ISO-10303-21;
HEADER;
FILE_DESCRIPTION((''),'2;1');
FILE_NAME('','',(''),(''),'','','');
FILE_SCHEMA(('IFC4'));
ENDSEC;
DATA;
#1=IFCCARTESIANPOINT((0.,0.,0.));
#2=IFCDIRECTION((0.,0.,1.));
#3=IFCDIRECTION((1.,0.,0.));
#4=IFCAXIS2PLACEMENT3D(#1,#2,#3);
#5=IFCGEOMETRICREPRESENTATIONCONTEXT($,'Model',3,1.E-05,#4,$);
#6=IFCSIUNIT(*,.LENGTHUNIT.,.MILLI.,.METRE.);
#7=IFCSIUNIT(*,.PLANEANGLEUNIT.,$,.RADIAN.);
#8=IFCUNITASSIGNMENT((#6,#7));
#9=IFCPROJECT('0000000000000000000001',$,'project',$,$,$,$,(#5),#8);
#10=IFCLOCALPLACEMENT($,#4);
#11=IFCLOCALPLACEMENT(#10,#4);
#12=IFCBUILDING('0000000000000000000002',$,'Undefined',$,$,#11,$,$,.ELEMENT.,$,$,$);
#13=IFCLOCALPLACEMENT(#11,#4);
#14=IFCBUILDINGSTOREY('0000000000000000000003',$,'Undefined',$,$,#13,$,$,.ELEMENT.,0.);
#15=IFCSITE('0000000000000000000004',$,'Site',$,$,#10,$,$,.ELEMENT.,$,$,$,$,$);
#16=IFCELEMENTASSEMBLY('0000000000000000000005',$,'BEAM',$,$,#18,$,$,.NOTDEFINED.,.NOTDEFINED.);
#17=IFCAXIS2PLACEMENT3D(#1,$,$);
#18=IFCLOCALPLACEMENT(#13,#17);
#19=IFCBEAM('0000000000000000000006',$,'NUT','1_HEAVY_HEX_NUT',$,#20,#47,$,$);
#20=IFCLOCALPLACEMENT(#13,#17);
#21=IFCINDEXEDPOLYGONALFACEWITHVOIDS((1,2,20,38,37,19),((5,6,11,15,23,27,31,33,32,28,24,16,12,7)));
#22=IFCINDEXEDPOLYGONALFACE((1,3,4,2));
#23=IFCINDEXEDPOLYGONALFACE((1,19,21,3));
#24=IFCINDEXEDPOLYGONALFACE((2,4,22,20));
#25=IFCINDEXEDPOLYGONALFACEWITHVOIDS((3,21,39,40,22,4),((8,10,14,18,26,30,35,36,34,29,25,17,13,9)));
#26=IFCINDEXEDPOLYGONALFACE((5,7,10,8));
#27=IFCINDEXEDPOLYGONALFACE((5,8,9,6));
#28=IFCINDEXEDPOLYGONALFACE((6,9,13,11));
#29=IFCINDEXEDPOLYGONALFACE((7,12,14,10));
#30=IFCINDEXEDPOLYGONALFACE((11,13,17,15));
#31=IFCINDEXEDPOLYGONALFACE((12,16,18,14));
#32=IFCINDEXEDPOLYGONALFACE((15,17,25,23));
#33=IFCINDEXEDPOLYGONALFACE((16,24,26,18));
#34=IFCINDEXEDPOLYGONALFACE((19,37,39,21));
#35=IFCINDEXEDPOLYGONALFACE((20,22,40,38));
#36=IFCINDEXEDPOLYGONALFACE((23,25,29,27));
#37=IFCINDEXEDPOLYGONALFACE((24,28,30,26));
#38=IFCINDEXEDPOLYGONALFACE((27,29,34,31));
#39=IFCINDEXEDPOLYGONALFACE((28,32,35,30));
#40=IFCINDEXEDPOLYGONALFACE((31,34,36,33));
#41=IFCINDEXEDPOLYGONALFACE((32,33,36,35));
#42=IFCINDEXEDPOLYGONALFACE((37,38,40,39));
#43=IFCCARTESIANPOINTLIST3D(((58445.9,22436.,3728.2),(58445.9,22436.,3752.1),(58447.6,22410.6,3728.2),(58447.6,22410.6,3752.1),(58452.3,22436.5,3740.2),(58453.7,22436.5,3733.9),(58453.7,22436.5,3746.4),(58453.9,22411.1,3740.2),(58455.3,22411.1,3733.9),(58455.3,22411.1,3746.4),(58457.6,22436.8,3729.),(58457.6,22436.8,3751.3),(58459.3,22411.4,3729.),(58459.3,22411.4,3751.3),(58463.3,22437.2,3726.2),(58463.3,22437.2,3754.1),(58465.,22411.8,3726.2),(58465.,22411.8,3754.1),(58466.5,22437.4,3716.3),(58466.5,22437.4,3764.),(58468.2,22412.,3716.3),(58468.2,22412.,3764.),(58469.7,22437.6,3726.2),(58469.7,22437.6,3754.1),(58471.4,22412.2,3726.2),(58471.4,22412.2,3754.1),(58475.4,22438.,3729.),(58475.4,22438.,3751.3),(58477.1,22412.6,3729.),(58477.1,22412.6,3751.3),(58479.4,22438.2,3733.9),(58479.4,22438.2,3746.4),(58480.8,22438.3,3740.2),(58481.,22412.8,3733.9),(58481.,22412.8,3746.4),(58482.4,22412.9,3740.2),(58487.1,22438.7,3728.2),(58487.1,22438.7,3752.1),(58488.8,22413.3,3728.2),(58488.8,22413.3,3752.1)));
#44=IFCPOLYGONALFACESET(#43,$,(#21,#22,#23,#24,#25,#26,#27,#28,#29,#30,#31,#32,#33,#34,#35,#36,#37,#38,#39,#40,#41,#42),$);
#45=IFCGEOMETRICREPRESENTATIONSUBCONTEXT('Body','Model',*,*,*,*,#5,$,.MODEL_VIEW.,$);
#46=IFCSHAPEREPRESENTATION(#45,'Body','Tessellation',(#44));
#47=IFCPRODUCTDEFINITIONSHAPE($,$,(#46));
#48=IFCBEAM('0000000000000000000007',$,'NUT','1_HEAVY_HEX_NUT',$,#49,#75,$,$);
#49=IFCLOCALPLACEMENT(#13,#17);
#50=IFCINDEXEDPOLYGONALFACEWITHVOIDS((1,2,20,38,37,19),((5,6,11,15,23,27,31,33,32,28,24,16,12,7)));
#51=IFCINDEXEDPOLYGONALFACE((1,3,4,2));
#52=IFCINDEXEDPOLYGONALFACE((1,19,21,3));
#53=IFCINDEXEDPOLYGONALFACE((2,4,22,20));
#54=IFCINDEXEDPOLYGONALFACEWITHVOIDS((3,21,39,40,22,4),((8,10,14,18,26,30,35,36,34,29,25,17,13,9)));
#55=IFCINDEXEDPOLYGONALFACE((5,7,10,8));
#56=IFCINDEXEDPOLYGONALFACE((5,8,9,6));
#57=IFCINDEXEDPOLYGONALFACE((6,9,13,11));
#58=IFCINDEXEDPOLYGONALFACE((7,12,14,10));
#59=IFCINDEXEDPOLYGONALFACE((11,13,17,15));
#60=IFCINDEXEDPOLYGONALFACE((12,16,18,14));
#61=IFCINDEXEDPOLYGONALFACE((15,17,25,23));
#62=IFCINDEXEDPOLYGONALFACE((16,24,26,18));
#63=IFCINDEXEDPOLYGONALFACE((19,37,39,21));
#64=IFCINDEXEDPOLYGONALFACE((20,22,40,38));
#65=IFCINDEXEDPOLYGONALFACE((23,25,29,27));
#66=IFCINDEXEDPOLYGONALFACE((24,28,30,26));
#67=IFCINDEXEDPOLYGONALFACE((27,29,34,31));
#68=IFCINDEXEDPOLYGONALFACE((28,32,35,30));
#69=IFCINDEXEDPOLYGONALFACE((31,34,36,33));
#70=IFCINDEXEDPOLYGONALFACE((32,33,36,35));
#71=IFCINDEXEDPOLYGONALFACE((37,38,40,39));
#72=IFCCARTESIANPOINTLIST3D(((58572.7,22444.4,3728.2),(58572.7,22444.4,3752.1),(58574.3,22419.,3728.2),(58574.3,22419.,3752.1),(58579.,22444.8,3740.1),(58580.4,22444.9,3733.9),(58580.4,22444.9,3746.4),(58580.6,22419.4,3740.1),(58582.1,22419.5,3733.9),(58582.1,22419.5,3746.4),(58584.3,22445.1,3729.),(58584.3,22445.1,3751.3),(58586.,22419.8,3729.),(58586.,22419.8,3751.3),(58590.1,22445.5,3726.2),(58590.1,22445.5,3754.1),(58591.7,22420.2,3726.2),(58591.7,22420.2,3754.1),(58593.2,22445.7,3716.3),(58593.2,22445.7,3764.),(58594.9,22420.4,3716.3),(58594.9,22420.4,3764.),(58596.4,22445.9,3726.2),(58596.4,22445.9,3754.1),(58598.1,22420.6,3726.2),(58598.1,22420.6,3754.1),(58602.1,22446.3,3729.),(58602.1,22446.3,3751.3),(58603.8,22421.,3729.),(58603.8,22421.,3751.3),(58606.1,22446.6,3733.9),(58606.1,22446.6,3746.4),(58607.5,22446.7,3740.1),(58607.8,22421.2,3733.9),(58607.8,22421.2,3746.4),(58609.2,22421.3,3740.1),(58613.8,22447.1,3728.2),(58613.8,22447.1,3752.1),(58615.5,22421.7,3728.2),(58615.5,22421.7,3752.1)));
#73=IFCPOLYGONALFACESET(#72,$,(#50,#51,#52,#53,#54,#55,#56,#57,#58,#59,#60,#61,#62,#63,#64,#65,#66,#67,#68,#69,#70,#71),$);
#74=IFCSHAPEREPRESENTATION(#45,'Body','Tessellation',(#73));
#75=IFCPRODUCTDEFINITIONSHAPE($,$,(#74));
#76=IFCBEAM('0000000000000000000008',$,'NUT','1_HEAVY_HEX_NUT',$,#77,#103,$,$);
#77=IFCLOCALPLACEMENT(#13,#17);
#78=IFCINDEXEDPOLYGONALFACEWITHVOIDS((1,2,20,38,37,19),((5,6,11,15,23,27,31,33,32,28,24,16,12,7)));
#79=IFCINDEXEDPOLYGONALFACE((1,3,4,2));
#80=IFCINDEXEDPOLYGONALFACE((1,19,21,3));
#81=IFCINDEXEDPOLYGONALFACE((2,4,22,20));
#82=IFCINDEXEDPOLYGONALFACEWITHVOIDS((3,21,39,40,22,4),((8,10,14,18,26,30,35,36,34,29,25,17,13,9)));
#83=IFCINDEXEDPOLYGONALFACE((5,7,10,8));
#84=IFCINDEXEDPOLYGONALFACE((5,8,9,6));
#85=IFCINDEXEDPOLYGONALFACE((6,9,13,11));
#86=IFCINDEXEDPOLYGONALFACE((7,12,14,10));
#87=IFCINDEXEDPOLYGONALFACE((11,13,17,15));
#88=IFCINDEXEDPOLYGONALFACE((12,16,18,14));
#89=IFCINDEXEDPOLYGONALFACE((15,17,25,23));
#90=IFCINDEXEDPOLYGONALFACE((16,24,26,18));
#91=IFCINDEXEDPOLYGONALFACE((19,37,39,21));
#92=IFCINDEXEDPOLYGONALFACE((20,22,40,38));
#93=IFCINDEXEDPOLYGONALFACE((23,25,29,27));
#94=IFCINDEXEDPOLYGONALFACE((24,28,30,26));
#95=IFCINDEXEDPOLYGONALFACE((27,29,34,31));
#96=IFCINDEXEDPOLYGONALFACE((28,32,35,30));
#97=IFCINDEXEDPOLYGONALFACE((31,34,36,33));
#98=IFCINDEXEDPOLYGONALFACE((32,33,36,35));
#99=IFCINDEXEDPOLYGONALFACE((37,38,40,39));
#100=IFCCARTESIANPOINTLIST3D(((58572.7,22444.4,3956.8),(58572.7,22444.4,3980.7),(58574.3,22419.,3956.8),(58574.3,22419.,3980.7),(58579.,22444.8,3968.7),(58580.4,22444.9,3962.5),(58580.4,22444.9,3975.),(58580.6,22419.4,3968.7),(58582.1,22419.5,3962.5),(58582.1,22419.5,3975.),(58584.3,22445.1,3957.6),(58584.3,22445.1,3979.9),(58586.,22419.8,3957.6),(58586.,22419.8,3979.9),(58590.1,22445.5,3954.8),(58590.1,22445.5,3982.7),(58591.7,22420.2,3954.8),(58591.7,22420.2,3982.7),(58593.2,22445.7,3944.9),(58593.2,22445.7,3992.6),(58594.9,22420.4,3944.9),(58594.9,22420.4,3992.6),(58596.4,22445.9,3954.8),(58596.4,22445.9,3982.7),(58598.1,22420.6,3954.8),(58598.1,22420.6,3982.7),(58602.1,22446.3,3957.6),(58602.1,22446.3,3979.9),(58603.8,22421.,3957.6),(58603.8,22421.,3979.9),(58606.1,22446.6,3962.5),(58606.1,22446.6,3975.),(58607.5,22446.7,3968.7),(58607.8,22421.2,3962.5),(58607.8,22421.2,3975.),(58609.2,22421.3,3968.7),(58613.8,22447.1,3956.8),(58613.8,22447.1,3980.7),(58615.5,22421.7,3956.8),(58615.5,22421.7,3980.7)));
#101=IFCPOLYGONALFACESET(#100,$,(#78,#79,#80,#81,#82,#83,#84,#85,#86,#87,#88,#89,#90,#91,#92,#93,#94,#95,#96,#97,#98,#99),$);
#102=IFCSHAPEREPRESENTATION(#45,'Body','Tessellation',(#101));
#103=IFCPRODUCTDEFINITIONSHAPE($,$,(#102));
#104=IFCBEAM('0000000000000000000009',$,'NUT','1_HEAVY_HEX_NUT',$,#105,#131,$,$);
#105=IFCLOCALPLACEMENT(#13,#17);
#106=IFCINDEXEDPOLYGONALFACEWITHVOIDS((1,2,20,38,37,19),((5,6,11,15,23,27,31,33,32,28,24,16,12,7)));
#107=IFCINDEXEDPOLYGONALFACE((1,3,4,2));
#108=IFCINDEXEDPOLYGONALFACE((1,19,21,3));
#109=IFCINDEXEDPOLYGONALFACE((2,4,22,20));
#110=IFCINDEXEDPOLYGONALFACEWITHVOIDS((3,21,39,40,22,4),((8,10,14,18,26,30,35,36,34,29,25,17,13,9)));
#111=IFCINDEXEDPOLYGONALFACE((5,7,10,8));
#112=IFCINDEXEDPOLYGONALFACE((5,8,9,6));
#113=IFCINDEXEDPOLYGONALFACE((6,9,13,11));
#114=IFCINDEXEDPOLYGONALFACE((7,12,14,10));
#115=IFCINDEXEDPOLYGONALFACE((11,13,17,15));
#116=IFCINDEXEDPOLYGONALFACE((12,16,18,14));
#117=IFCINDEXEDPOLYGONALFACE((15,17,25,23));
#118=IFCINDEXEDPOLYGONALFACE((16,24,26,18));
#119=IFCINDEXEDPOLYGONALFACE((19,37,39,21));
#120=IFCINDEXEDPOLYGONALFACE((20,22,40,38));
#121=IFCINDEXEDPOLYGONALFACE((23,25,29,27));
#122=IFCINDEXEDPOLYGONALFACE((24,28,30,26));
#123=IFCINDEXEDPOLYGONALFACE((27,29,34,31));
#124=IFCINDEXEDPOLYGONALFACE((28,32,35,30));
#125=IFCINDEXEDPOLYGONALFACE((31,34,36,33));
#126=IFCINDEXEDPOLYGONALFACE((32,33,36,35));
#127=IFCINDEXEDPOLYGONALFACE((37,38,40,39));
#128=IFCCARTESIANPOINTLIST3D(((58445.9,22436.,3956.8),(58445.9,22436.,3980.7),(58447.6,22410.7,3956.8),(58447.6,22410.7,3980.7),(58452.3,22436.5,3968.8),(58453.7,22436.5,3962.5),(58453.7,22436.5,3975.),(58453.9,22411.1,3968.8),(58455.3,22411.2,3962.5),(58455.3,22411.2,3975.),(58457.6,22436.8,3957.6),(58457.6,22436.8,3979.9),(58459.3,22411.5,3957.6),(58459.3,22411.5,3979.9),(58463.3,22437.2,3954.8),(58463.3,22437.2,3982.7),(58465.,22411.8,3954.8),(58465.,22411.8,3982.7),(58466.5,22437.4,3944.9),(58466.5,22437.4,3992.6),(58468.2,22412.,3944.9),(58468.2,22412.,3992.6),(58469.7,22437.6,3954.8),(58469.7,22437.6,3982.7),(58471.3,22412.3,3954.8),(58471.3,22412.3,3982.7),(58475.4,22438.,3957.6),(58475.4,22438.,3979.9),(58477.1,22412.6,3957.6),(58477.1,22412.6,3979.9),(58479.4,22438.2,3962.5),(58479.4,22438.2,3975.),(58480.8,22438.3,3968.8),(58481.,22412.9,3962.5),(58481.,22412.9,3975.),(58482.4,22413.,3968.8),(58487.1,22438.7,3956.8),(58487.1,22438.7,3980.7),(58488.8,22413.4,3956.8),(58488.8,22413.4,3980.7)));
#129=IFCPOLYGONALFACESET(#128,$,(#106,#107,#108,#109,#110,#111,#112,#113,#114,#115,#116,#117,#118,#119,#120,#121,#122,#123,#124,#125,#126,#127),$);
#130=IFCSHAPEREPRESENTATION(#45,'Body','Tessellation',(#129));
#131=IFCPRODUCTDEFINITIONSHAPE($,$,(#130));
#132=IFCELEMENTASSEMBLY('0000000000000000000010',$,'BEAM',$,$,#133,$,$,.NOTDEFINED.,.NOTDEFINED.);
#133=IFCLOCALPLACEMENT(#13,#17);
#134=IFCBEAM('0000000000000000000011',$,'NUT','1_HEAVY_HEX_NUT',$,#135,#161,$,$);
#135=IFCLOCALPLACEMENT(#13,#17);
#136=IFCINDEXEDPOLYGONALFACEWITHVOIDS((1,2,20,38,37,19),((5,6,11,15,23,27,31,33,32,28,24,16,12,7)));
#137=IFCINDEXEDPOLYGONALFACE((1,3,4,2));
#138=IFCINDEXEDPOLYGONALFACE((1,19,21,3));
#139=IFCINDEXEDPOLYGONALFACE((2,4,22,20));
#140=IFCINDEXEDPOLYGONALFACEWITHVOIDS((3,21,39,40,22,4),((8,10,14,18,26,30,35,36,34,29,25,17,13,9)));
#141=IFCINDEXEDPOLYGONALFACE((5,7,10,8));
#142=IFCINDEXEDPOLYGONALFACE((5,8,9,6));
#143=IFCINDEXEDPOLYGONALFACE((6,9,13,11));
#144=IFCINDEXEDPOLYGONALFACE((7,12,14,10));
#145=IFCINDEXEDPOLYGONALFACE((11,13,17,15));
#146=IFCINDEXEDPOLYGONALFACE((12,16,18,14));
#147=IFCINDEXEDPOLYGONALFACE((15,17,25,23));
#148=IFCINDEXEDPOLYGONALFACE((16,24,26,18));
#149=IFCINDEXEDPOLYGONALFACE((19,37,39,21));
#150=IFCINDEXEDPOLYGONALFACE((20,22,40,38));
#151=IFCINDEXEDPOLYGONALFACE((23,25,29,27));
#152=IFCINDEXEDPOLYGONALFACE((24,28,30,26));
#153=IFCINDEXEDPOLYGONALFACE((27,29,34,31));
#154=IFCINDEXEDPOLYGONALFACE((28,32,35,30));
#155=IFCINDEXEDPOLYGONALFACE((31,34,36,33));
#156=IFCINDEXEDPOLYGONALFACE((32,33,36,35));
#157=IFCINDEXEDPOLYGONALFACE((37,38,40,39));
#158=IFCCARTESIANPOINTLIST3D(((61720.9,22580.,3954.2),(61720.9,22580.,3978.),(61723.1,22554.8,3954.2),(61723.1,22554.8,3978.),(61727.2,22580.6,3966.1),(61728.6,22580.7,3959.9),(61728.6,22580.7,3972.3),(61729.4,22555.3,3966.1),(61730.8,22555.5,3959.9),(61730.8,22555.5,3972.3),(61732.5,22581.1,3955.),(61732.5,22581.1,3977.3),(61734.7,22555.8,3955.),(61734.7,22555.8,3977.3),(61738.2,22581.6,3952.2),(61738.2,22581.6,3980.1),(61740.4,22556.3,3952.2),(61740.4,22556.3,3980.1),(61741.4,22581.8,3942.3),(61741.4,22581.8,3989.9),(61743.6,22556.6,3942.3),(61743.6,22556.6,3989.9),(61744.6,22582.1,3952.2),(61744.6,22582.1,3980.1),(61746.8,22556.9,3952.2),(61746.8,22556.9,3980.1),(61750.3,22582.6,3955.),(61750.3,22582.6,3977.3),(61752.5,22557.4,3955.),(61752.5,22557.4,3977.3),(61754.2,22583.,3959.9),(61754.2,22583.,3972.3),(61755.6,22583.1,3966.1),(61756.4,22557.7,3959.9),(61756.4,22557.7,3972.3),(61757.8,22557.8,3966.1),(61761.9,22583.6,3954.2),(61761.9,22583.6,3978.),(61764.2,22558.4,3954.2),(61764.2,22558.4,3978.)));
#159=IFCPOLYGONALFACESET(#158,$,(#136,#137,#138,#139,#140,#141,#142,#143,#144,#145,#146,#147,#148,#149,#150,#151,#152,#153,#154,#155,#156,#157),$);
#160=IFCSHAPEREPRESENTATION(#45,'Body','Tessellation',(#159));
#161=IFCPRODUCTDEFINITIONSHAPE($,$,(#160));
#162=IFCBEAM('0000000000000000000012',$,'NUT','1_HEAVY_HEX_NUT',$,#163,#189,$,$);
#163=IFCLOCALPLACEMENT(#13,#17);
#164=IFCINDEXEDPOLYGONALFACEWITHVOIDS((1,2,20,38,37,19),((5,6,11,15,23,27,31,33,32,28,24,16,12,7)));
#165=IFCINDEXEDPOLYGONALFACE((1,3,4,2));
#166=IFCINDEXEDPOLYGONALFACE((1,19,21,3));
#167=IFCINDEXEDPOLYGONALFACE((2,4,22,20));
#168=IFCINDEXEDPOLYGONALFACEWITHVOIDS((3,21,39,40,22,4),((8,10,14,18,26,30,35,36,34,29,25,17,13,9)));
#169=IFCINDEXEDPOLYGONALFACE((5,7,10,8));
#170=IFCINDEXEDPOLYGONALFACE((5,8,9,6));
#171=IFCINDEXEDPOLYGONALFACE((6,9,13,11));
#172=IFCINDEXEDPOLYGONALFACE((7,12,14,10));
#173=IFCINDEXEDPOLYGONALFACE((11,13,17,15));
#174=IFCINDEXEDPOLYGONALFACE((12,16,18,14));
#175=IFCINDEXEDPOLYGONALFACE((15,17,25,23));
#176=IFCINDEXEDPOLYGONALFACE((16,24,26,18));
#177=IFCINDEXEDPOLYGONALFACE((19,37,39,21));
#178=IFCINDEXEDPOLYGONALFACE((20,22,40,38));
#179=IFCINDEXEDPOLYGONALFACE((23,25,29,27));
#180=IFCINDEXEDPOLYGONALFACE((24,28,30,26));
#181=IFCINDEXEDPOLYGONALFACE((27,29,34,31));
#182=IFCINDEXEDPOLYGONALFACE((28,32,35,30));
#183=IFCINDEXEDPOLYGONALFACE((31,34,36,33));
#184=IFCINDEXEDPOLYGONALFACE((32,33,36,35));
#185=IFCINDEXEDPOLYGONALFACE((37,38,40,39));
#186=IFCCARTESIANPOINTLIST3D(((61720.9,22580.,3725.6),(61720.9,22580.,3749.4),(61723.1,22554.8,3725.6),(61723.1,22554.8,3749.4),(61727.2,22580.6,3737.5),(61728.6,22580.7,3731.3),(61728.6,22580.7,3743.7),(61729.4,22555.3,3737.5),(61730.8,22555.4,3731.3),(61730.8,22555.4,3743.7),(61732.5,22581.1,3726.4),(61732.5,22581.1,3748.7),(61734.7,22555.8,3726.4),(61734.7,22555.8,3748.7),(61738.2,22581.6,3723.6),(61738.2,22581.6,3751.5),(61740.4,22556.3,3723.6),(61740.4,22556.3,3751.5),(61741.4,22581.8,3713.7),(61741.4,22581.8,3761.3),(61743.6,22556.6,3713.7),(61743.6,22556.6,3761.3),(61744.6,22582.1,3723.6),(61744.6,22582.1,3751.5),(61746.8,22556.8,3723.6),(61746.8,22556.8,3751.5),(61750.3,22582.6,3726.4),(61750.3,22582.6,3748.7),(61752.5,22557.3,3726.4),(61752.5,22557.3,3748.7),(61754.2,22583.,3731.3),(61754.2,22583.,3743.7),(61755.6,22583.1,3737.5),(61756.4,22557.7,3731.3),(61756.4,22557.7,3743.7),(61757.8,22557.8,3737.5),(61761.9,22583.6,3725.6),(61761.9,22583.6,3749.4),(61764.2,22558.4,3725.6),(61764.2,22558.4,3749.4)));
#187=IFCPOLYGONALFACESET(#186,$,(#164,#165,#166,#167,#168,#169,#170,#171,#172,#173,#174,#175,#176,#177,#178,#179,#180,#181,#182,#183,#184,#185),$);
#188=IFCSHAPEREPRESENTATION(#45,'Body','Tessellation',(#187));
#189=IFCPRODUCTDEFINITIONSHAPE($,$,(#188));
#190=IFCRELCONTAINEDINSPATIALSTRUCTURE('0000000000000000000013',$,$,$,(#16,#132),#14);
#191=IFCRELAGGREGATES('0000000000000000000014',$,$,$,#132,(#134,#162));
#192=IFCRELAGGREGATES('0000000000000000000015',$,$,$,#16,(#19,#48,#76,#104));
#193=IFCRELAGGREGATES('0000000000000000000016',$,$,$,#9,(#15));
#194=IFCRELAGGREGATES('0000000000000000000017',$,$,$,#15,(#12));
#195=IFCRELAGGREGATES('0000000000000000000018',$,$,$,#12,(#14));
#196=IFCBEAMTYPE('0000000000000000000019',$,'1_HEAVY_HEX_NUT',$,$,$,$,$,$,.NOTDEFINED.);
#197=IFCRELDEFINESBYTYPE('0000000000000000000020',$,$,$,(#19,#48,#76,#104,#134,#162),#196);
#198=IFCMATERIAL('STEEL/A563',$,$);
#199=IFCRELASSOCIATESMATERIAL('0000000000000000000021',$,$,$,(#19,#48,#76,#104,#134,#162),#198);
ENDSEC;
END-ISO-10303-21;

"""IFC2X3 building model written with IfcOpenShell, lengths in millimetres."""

from ifc_helpers import new_model, si_unit, frame, origin_with_axes, place, context, subcontext, project, spatial, polyline, outline, extrude, material, type_object, element, aggregate, save


model = new_model("IFC2X3")

# Units and contexts
model_context = context("Model", 3, precision=1e-05, world=origin_with_axes())
body_context = subcontext(model_context, "Body", "Model", "MODEL_VIEW")
ifc_project = project(units=[si_unit("LENGTHUNIT", "METRE", prefix="MILLI"), si_unit("PLANEANGLEUNIT", "RADIAN")], contexts=[model_context])

# Site, building, storey
site_placement = place(None, origin_with_axes())
site = spatial("IfcSite", under=ifc_project, at=site_placement, Name="Site", CompositionType="ELEMENT")
building_placement = place(site_placement, origin_with_axes())
building = spatial("IfcBuilding", under=site, at=building_placement, Name="Undefined", CompositionType="ELEMENT")
storey_placement = place(building_placement, origin_with_axes())
storey = spatial("IfcBuildingStorey", under=building, at=storey_placement, Name="Undefined", CompositionType="ELEMENT", Elevation=0.0)

# Element assemblies, beams
assembly_1_placement = place(storey_placement, origin_with_axes())
assembly_1 = element("IfcElementAssembly", 1, at=assembly_1_placement, inside=storey, Name="BEAM", AssemblyPlace="NOTDEFINED", PredefinedType="NOTDEFINED")
ifc_material_1 = material(Name="STEEL/A563")
beam_type_1 = type_object("IfcBeamType", Name="1_HEAVY_HEX_NUT", PredefinedType="NOTDEFINED")
beam_1_placement = place(assembly_1_placement, frame((58466.5, 22437.4, 3740.2), z_axis=(-0.997848, -0.065571, 0.0), x_axis=(0.065571, -0.997848, 0.0)))
beam_1 = element("IfcBeam", 2, at=beam_1_placement, type_object=beam_type_1, material=ifc_material_1, Name="NUT", Description="1_HEAVY_HEX_NUT", context=body_context, shape_type="SweptSolid", body=[
    extrude(outline(polyline([(-11.9, -20.6), (-23.8, 0.0), (-11.9, 20.6), (11.9, 20.6), (23.8, 0.0), (11.9, -20.6), (-11.9, -20.6)]), holes=[polyline([(11.2, 8.9), (6.2, 12.9), (0.0, 14.3), (-6.2, 12.9), (-11.2, 8.9), (-13.9, 3.2), (-13.9, -3.2), (-11.2, -8.9), (-6.2, -12.9), (0.0, -14.3), (6.2, -12.9), (11.2, -8.9), (13.9, -3.2), (13.9, 3.2), (11.2, 8.9)])]), frame((25.5, 0.0, 0.0), z_axis=(-1.0, 0.0, 0.0), x_axis=(0.0, -1.0, 0.0)), (0.0, 0.0, 1.0), 25.4),
])
beam_2_placement = place(assembly_1_placement, frame((58593.2, 22445.7, 3740.1), z_axis=(-0.997848, -0.065571, 0.0), x_axis=(0.065571, -0.997848, 0.0)))
beam_2 = element("IfcBeam", 3, at=beam_2_placement, type_object=beam_type_1, material=ifc_material_1, Name="NUT", Description="1_HEAVY_HEX_NUT", context=body_context, shape_type="SweptSolid", body=[
    extrude(outline(polyline([(-11.9, -20.6), (-23.8, 0.0), (-11.9, 20.6), (11.9, 20.6), (23.8, 0.0), (11.9, -20.6), (-11.9, -20.6)]), holes=[polyline([(11.2, 8.9), (6.2, 12.9), (0.0, 14.3), (-6.2, 12.9), (-11.2, 8.9), (-13.9, 3.2), (-13.9, -3.2), (-11.2, -8.9), (-6.2, -12.9), (0.0, -14.3), (6.2, -12.9), (11.2, -8.9), (13.9, -3.2), (13.9, 3.2), (11.2, 8.9)])]), frame((25.4, 0.0, 0.0), z_axis=(-1.0, 0.0, 0.0), x_axis=(0.0, -1.0, 0.0)), (0.0, 0.0, 1.0), 25.4),
])
beam_3_placement = place(assembly_1_placement, frame((58593.2, 22445.7, 3968.7), z_axis=(-0.997848, -0.065571, 0.0), x_axis=(0.065571, -0.997848, 0.0)))
beam_3 = element("IfcBeam", 4, at=beam_3_placement, type_object=beam_type_1, material=ifc_material_1, Name="NUT", Description="1_HEAVY_HEX_NUT", context=body_context, shape_type="SweptSolid", body=[
    extrude(outline(polyline([(-11.9, -20.6), (-23.8, 0.0), (-11.9, 20.6), (11.9, 20.6), (23.8, 0.0), (11.9, -20.6), (-11.9, -20.6)]), holes=[polyline([(11.2, 8.9), (6.2, 12.9), (0.0, 14.3), (-6.2, 12.9), (-11.2, 8.9), (-13.9, 3.2), (-13.9, -3.2), (-11.2, -8.9), (-6.2, -12.9), (0.0, -14.3), (6.2, -12.9), (11.2, -8.9), (13.9, -3.2), (13.9, 3.2), (11.2, 8.9)])]), frame((25.4, 0.0, 0.0), z_axis=(-1.0, 0.0, 0.0), x_axis=(0.0, -1.0, 0.0)), (0.0, 0.0, 1.0), 25.4),
])
beam_4_placement = place(assembly_1_placement, frame((58466.5, 22437.4, 3968.8), z_axis=(-0.997848, -0.065571, 0.0), x_axis=(0.065571, -0.997848, 0.0)))
beam_4 = element("IfcBeam", 5, at=beam_4_placement, type_object=beam_type_1, material=ifc_material_1, Name="NUT", Description="1_HEAVY_HEX_NUT", context=body_context, shape_type="SweptSolid", body=[
    extrude(outline(polyline([(-11.9, -20.6), (-23.8, 0.0), (-11.9, 20.6), (11.9, 20.6), (23.8, 0.0), (11.9, -20.6), (-11.9, -20.6)]), holes=[polyline([(11.2, 8.9), (6.2, 12.9), (0.0, 14.3), (-6.2, 12.9), (-11.2, 8.9), (-13.9, 3.2), (-13.9, -3.2), (-11.2, -8.9), (-6.2, -12.9), (0.0, -14.3), (6.2, -12.9), (11.2, -8.9), (13.9, -3.2), (13.9, 3.2), (11.2, 8.9)])]), frame((25.4, 0.0, 0.0), z_axis=(-1.0, 0.0, 0.0), x_axis=(0.0, -1.0, 0.0)), (0.0, 0.0, 1.0), 25.4),
])
assembly_2_placement = place(storey_placement, origin_with_axes())
assembly_2 = element("IfcElementAssembly", 6, at=assembly_2_placement, inside=storey, Name="BEAM", AssemblyPlace="NOTDEFINED", PredefinedType="NOTDEFINED")
beam_5_placement = place(assembly_2_placement, frame((61743.6, 22556.6, 3966.1), z_axis=(0.996183, 0.087293, 0.0), x_axis=(-0.087293, 0.996183, 0.000005)))
beam_5 = element("IfcBeam", 7, at=beam_5_placement, type_object=beam_type_1, material=ifc_material_1, Name="NUT", Description="1_HEAVY_HEX_NUT", context=body_context, shape_type="SweptSolid", body=[
    extrude(outline(polyline([(-11.9, -20.6), (-23.8, 0.0), (-11.9, 20.6), (11.9, 20.6), (23.8, 0.0), (11.9, -20.6), (-11.9, -20.6)]), holes=[polyline([(11.2, 8.9), (6.2, 12.9), (0.0, 14.3), (-6.2, 12.9), (-11.2, 8.9), (-13.9, 3.2), (-13.9, -3.2), (-11.2, -8.9), (-6.2, -12.9), (0.0, -14.3), (6.2, -12.9), (11.2, -8.9), (13.9, -3.2), (13.9, 3.2), (11.2, 8.9)])]), frame((25.3, 0.0, 0.0), z_axis=(-1.0, 0.0, 0.0), x_axis=(0.0, -1.0, 0.0)), (0.0, 0.0, 1.0), 25.3),
])
beam_6_placement = place(assembly_2_placement, frame((61743.6, 22556.6, 3737.5), z_axis=(0.996183, 0.087293, 0.0), x_axis=(-0.087293, 0.996183, 0.000005)))
beam_6 = element("IfcBeam", 8, at=beam_6_placement, type_object=beam_type_1, material=ifc_material_1, Name="NUT", Description="1_HEAVY_HEX_NUT", context=body_context, shape_type="SweptSolid", body=[
    extrude(outline(polyline([(-11.9, -20.6), (-23.8, 0.0), (-11.9, 20.6), (11.9, 20.6), (23.8, 0.0), (11.9, -20.6), (-11.9, -20.6)]), holes=[polyline([(11.2, 8.9), (6.2, 12.9), (0.0, 14.3), (-6.2, 12.9), (-11.2, 8.9), (-13.9, 3.2), (-13.9, -3.2), (-11.2, -8.9), (-6.2, -12.9), (0.0, -14.3), (6.2, -12.9), (11.2, -8.9), (13.9, -3.2), (13.9, 3.2), (11.2, 8.9)])]), frame((25.4, 0.0, 0.0), z_axis=(-1.0, 0.0, 0.0), x_axis=(0.0, -1.0, 0.0)), (0.0, 0.0, 1.0), 25.4),
])

aggregate(assembly_2, [beam_5, beam_6])

aggregate(assembly_1, [beam_1, beam_2, beam_3, beam_4])

save(model, "model.ifc")
